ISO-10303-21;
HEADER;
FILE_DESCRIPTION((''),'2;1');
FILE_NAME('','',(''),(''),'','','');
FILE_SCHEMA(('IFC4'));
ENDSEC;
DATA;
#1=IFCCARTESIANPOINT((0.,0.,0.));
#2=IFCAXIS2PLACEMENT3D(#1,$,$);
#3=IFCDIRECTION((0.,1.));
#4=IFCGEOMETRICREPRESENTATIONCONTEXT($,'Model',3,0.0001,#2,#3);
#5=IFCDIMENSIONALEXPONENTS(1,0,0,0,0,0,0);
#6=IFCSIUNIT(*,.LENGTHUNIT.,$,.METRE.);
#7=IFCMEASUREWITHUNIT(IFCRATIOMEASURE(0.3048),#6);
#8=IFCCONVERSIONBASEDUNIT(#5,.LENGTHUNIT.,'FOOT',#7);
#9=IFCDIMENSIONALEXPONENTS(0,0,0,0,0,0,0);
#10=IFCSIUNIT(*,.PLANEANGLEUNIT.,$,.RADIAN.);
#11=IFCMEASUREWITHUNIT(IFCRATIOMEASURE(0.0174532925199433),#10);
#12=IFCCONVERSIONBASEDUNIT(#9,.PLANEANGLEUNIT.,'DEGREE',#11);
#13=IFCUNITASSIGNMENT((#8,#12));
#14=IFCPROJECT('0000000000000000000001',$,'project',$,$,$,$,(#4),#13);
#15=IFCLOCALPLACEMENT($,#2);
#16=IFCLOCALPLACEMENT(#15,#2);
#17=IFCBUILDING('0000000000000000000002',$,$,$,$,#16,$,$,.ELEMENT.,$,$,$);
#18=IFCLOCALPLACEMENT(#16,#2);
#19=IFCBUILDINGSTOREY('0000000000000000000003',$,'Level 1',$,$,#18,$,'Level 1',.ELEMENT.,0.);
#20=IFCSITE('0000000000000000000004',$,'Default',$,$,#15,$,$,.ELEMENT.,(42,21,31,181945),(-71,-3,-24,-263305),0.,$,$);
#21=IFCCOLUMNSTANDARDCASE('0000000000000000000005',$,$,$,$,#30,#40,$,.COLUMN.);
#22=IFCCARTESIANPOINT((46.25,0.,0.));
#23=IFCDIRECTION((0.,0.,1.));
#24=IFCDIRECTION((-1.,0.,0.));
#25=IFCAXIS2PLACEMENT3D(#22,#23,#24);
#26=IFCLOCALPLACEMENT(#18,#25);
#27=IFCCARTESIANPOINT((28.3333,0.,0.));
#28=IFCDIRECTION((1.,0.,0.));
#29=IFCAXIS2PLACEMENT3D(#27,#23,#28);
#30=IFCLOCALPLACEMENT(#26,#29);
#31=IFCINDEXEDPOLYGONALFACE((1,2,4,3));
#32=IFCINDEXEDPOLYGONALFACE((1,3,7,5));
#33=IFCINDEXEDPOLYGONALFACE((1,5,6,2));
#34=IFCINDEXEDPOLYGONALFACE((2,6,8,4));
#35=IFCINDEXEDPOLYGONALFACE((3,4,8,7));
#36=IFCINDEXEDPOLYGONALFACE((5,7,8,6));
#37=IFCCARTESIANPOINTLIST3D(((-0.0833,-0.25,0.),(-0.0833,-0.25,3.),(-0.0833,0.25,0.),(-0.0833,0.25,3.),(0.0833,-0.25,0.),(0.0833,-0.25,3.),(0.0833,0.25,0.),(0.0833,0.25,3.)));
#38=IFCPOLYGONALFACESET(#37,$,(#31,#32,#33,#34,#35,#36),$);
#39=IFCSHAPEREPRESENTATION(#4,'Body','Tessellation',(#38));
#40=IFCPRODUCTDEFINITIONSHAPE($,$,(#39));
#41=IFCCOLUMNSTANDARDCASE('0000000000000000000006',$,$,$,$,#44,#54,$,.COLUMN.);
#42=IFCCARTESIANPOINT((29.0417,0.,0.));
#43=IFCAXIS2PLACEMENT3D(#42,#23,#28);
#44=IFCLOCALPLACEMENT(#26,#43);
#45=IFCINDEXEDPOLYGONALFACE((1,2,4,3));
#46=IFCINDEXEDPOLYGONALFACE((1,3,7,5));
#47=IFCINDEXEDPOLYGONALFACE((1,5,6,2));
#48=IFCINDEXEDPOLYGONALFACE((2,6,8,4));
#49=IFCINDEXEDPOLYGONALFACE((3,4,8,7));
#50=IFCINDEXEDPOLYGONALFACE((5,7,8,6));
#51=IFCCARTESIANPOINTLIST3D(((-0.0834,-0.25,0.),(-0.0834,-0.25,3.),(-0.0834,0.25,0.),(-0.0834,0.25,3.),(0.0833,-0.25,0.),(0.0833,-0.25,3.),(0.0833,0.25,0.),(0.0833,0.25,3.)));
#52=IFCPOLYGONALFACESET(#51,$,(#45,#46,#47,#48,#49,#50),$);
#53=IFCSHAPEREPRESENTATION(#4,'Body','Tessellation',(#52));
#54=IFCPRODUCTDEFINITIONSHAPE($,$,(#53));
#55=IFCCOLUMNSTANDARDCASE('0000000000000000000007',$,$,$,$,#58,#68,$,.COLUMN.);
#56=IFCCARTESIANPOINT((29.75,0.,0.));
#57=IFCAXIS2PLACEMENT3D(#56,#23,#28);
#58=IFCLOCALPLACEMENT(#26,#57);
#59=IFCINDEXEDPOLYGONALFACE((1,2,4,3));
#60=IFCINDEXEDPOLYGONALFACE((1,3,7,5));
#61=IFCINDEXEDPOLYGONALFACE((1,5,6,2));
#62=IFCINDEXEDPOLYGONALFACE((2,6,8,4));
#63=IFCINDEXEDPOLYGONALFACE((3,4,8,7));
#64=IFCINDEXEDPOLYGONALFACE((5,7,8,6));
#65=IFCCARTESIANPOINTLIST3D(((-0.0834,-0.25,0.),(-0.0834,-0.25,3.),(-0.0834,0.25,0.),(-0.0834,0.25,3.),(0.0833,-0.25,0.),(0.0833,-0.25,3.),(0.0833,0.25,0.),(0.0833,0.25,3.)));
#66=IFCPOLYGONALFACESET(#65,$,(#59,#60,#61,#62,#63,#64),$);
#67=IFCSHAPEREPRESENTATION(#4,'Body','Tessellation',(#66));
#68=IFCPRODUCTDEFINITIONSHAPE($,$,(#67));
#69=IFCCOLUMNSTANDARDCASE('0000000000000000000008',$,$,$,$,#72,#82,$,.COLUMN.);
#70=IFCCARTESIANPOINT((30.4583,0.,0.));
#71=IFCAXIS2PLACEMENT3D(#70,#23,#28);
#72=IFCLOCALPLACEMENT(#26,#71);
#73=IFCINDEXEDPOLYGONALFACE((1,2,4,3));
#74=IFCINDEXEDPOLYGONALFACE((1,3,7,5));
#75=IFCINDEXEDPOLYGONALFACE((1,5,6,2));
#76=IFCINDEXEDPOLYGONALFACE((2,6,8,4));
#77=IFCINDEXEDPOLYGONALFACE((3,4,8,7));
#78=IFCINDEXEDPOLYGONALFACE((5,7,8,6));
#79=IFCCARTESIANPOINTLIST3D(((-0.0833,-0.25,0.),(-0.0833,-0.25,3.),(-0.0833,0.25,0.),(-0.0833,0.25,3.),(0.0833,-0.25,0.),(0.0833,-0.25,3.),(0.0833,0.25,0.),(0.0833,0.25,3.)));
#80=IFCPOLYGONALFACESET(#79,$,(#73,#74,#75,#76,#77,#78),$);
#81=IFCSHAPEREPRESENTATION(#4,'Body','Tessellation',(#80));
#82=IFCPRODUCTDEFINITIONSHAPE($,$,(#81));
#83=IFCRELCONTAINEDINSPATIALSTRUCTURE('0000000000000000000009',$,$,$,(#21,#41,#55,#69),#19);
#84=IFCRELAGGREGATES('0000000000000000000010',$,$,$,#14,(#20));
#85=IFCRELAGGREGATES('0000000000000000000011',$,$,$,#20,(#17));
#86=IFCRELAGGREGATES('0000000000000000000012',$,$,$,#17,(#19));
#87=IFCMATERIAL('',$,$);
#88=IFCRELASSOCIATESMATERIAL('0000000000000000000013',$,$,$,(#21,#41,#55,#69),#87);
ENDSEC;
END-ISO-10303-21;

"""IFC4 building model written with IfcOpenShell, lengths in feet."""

from ifc_helpers import new_model, entity, si_unit, converted_unit, direction, frame, origin, place, context, project, spatial, rectangle, extrude, material, element, save


model = new_model("IFC4")

# Units and contexts
model_context = context("Model", 3, precision=0.0001, world=origin(), true_north=direction((0.0, 1.0)))
ifc_project = project(units=[converted_unit("LENGTHUNIT", "FOOT", entity("IfcRatioMeasure", 0.3048), si_unit("LENGTHUNIT", "METRE"), dimensions=[1, 0, 0, 0, 0, 0, 0]), converted_unit("PLANEANGLEUNIT", "DEGREE", entity("IfcRatioMeasure", 0.0174532925199433), si_unit("PLANEANGLEUNIT", "RADIAN"), dimensions=[0, 0, 0, 0, 0, 0, 0])], contexts=[model_context])

# Site, building, storey
site_placement = place(None, origin())
site = spatial("IfcSite", under=ifc_project, at=site_placement, Name="Default", CompositionType="ELEMENT", RefLatitude=(42, 21, 31, 181945), RefLongitude=(-71, -3, -24, -263305), RefElevation=0.0)
building_placement = place(site_placement, origin())
building = spatial("IfcBuilding", under=site, at=building_placement, CompositionType="ELEMENT")
storey_placement = place(building_placement, origin())
storey = spatial("IfcBuildingStorey", under=building, at=storey_placement, Name="Level 1", LongName="Level 1", CompositionType="ELEMENT", Elevation=0.0)

# Columns
placement = place(storey_placement, frame((46.25, 0.0, 0.0), z_axis=(0.0, 0.0, 1.0), x_axis=(-1.0, 0.0, 0.0)))
ifc_material_1 = material(Name="")
for number, where, z_axis, x_axis in (
    (1, (28.3333, 0.0, 0.0), (0.0, 0.0, 1.0), (1.0, 0.0, 0.0)),
    (2, (29.0417, 0.0, 0.0), (0.0, 0.0, 1.0), (1.0, 0.0, 0.0)),
    (3, (29.75, 0.0, 0.0), (0.0, 0.0, 1.0), (1.0, 0.0, 0.0)),
    (4, (30.4583, 0.0, 0.0), (0.0, 0.0, 1.0), (1.0, 0.0, 0.0)),
):
    element("IfcColumnStandardCase", number, at=place(placement, frame(where, z_axis=z_axis, x_axis=x_axis)), inside=storey, material=ifc_material_1, PredefinedType="COLUMN", context=model_context, shape_type="SweptSolid", body=[
        extrude(rectangle(XDim=0.1667, YDim=0.5), origin(), (0.0, 0.0, 1.0), 3.0),
    ])

save(model, "model.ifc")
